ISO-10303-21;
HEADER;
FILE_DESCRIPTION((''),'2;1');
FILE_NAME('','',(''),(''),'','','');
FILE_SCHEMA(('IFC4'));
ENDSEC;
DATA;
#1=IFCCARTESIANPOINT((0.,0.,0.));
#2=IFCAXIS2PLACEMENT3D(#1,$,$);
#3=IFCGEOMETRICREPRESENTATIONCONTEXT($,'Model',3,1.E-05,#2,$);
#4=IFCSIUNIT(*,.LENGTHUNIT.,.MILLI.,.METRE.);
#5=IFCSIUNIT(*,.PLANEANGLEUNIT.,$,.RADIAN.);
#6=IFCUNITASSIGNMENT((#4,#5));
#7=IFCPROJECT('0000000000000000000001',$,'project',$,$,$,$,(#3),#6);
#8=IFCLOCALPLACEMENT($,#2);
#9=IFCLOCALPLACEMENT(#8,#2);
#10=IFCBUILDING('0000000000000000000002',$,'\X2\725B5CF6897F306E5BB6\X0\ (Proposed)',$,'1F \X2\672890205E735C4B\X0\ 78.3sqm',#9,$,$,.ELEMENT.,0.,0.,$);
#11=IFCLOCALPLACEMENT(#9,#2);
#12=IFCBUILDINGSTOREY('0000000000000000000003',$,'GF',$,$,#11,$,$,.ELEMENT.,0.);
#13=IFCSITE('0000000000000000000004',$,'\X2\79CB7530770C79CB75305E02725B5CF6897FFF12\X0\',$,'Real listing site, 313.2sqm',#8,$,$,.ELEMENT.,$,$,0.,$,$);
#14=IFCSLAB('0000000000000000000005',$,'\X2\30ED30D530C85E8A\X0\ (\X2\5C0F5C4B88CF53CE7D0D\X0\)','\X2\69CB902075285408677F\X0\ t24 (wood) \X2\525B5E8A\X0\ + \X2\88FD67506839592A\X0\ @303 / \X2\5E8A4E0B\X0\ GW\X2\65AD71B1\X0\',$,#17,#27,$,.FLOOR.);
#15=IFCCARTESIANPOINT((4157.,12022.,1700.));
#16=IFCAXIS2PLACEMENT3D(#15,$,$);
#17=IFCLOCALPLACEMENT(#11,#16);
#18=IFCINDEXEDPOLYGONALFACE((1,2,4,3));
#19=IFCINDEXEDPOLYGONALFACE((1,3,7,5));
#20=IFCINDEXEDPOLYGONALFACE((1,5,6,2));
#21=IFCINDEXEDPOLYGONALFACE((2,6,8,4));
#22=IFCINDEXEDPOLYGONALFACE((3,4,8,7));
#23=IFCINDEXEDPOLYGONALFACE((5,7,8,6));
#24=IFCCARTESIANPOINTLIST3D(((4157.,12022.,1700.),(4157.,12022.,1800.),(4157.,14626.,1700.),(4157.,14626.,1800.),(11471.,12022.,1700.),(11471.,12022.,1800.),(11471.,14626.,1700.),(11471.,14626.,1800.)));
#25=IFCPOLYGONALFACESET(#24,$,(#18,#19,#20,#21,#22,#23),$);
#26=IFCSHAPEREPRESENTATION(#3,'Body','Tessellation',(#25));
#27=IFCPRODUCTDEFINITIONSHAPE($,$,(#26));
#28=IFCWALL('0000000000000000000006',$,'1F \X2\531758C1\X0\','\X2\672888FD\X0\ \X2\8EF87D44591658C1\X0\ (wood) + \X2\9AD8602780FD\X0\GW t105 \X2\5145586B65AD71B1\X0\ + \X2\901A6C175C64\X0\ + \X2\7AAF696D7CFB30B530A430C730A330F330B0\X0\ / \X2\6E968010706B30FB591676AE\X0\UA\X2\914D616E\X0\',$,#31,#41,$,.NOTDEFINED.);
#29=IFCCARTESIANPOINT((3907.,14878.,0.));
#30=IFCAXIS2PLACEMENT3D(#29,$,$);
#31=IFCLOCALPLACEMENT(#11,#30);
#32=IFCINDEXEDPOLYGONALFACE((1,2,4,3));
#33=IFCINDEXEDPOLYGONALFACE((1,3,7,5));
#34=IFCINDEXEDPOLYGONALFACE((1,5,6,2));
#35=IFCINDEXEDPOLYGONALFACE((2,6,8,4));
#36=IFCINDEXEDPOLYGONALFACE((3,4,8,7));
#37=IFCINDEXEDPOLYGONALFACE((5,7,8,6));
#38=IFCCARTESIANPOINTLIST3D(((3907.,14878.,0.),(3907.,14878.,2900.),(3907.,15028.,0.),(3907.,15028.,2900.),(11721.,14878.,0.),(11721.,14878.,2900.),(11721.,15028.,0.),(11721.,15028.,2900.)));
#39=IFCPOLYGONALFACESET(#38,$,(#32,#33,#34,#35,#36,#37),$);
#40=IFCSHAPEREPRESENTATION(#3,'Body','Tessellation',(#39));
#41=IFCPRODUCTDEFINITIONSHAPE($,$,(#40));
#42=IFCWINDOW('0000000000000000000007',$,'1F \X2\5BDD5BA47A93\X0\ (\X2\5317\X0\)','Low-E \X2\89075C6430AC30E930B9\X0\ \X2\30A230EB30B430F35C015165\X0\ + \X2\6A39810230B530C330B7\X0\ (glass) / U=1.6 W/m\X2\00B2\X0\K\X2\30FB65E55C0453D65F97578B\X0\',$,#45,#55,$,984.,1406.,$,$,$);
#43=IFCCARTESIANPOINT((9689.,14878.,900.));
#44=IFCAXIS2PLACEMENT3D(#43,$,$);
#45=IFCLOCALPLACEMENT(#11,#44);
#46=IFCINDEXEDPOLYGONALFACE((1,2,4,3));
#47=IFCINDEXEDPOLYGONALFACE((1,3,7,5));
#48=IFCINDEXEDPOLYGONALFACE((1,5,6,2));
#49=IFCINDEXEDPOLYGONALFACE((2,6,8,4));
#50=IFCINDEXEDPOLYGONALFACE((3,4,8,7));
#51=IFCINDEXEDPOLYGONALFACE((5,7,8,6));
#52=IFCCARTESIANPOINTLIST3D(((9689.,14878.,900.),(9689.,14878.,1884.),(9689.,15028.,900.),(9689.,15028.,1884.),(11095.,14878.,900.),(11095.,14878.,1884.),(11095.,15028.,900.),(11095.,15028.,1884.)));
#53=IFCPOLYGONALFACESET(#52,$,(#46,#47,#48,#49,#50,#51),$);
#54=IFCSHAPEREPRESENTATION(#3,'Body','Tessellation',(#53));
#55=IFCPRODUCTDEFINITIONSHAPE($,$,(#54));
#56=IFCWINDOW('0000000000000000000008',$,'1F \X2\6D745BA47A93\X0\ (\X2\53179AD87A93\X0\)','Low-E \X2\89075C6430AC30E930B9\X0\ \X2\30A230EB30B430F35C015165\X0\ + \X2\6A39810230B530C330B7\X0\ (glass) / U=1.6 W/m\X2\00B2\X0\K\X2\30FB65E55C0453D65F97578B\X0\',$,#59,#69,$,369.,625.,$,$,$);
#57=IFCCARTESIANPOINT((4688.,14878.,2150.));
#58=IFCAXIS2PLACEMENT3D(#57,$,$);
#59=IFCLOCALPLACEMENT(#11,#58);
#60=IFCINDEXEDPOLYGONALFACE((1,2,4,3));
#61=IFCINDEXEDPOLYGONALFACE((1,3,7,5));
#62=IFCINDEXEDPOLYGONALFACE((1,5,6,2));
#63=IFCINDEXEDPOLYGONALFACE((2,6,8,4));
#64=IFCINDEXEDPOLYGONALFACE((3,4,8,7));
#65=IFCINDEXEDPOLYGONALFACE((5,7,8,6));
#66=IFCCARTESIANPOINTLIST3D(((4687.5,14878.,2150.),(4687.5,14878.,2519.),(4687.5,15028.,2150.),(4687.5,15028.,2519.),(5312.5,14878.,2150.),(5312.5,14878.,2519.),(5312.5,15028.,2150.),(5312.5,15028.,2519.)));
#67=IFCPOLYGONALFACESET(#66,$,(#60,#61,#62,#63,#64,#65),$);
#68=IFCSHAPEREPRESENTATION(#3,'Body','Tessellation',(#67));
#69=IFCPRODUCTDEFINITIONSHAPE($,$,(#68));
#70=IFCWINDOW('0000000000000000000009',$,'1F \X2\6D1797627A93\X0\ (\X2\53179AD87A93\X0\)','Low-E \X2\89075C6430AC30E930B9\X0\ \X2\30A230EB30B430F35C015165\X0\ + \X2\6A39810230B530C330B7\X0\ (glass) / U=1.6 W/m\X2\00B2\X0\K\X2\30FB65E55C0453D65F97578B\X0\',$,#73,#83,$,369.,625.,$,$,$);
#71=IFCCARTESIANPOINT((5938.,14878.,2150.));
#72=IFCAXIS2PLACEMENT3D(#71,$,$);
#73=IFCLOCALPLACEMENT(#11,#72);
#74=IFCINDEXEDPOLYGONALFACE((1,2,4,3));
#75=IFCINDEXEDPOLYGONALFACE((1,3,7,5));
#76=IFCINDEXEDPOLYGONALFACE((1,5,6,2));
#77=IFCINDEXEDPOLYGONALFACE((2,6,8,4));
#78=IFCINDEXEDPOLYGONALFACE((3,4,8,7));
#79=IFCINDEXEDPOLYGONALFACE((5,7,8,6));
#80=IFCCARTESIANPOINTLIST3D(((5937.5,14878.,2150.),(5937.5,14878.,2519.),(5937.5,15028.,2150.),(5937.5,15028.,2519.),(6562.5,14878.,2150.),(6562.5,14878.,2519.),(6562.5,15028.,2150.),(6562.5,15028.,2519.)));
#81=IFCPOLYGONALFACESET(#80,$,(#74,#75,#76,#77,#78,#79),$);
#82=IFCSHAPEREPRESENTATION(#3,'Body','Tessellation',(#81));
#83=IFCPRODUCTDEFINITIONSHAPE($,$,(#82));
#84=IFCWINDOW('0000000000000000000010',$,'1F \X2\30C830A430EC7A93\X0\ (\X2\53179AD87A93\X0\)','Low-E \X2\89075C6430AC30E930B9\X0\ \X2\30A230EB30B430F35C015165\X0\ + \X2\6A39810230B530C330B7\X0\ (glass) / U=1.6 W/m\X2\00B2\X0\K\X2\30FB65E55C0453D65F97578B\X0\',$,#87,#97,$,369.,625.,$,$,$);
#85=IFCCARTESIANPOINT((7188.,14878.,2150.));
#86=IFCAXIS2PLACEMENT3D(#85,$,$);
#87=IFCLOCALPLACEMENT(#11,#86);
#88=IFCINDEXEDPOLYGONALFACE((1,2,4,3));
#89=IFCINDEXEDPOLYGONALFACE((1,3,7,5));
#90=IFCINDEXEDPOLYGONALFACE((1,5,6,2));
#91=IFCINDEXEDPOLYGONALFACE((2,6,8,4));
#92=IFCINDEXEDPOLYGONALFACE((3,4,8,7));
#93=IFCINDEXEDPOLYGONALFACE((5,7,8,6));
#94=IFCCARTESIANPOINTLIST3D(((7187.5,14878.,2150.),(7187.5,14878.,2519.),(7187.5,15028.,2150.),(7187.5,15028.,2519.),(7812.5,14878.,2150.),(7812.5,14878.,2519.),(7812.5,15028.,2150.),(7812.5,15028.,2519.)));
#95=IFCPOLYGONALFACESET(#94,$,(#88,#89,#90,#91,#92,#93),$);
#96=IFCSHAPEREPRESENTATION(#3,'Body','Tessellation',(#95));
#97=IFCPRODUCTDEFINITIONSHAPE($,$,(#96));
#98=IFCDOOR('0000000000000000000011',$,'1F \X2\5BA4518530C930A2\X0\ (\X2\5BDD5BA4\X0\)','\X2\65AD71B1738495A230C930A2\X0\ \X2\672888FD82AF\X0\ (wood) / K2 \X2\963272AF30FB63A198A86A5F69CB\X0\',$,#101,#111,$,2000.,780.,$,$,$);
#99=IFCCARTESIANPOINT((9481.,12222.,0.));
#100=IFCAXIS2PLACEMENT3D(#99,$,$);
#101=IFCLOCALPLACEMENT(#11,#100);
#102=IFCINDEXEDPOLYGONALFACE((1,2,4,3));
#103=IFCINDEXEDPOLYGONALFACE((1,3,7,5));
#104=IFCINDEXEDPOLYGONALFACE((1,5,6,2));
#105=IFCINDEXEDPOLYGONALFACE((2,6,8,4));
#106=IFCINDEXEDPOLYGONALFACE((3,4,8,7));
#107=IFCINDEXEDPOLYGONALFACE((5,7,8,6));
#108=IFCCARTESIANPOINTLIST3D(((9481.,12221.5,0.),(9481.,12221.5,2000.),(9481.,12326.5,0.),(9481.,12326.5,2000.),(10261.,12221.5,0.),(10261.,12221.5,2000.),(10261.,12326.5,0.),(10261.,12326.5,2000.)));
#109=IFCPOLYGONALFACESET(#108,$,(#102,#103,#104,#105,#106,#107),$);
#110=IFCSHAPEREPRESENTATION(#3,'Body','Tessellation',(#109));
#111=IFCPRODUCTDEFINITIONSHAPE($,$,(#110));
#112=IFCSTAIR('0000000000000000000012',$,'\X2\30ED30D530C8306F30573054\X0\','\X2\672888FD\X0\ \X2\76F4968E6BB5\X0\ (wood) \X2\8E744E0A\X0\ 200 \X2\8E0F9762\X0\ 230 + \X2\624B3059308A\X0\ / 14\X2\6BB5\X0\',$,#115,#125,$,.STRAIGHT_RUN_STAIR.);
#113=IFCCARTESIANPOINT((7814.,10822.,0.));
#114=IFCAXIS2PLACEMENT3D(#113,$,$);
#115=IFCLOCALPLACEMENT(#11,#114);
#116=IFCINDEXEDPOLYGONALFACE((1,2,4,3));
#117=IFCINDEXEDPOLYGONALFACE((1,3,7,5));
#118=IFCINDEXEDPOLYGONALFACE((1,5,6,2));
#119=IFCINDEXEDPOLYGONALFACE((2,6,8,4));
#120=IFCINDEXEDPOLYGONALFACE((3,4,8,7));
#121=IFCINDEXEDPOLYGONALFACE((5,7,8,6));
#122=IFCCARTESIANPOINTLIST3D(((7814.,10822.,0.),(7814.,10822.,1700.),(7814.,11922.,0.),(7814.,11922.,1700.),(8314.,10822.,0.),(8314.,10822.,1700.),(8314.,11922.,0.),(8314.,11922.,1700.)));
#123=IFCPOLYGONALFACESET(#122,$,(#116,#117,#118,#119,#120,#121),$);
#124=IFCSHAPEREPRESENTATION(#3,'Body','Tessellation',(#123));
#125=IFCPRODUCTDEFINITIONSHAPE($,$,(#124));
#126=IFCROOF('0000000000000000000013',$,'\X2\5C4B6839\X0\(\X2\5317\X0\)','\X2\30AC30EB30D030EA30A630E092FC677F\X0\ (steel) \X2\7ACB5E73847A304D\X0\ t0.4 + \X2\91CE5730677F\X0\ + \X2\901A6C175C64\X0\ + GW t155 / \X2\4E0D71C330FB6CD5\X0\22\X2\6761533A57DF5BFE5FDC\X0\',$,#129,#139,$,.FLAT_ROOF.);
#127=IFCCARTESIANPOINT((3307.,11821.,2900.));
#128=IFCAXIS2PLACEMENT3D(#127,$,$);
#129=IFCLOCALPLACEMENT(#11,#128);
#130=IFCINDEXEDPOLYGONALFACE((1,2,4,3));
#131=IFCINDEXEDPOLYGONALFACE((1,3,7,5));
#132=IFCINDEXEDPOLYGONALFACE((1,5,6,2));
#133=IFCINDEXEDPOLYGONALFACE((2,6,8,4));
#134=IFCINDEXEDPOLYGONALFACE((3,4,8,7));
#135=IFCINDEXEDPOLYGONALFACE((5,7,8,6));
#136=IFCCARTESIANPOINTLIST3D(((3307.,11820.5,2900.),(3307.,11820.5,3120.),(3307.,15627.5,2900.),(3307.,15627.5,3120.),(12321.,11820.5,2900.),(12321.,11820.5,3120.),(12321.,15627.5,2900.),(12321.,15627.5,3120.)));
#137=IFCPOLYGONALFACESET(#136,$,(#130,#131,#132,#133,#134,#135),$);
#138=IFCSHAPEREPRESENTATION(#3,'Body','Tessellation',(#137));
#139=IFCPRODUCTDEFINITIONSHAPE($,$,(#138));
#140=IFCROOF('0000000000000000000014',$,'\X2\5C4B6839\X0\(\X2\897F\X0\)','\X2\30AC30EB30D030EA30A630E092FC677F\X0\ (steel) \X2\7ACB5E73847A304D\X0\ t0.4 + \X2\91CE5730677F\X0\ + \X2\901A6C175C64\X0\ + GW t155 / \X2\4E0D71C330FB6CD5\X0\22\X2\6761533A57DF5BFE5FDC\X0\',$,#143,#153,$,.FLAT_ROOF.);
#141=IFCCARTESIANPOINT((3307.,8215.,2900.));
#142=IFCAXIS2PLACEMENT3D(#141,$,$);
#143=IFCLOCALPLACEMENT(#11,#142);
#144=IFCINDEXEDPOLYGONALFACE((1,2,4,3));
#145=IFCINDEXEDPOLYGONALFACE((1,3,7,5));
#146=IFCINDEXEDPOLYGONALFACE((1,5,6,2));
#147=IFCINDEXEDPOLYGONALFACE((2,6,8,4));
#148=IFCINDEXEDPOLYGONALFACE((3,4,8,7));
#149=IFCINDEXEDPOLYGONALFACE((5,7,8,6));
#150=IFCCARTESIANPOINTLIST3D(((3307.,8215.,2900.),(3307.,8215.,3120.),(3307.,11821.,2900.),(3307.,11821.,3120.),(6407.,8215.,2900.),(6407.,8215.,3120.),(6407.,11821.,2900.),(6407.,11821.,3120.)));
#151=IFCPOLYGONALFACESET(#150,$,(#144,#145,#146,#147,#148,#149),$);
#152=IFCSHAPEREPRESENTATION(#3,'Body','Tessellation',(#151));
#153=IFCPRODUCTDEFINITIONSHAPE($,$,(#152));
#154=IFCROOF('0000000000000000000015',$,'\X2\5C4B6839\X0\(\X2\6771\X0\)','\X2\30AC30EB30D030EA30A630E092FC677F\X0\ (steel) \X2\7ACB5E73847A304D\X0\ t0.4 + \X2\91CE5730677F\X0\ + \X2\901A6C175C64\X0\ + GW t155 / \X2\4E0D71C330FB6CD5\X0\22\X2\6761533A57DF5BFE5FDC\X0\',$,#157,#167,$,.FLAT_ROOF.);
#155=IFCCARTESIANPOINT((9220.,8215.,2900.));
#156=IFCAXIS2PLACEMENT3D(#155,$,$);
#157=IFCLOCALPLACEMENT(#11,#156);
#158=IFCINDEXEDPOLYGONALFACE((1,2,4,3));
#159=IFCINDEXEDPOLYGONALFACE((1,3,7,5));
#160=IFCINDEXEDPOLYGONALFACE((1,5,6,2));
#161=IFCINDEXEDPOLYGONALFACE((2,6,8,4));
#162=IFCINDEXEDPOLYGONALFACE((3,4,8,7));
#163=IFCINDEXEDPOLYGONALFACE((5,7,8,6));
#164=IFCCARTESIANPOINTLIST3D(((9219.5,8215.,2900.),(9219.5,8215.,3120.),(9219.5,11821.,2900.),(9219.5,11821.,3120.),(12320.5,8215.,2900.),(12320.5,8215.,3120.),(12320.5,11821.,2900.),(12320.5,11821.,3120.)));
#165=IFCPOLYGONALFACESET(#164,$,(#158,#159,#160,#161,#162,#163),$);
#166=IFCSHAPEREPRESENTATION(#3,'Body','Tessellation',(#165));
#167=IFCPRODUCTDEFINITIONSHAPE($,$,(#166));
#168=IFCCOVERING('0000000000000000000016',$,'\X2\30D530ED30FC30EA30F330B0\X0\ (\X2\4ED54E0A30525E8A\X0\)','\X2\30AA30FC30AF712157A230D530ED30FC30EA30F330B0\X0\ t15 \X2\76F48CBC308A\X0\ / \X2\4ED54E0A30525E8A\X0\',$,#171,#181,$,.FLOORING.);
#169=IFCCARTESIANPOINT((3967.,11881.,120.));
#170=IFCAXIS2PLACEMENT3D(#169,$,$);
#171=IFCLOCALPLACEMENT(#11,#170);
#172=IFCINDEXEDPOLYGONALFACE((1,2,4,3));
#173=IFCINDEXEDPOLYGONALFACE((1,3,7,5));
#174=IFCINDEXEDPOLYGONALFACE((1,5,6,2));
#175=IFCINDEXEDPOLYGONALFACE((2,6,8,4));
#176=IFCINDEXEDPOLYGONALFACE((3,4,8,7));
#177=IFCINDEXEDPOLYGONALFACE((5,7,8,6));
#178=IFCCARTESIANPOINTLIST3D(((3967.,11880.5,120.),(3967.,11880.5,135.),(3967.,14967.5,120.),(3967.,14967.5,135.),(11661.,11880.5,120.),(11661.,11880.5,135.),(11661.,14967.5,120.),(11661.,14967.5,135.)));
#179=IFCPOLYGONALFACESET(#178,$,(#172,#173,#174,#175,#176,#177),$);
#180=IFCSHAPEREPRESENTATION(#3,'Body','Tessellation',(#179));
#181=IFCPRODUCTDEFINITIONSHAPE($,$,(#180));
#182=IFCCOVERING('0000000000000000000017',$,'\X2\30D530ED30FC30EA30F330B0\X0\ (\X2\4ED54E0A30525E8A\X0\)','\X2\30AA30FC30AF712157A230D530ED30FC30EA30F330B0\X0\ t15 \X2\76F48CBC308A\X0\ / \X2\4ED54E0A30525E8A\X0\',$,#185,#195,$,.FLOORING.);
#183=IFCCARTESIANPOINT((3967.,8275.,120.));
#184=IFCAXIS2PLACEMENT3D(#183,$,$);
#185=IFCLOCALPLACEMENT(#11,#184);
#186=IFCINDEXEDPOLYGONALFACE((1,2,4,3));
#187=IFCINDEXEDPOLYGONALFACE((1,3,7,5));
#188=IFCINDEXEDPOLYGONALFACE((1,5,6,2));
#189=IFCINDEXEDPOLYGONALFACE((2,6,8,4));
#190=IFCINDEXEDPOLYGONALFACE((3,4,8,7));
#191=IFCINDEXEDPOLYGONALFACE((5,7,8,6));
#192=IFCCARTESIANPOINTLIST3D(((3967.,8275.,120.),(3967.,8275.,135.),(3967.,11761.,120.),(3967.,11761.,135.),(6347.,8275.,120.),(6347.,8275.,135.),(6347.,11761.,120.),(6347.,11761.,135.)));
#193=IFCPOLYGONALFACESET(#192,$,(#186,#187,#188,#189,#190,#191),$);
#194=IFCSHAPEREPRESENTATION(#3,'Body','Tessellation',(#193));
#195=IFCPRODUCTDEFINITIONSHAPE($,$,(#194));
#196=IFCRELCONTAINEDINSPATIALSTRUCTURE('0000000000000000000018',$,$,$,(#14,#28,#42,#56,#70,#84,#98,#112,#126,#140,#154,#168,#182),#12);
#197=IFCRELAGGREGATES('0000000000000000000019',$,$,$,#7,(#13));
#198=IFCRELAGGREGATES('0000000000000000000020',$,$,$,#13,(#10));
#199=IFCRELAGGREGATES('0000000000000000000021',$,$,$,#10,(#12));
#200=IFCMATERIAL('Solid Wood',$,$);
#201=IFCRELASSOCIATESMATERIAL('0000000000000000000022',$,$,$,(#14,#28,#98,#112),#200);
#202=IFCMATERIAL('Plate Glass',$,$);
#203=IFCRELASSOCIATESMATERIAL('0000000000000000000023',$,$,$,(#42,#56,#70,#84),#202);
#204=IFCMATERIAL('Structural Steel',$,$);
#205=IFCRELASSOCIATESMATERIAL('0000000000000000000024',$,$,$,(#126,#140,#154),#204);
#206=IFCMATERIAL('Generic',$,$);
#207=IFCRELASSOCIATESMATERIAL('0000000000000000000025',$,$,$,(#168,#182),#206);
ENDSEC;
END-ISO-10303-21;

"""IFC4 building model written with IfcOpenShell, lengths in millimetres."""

from ifc_helpers import new_model, si_unit, frame, frame_2d, origin, place, context, project, spatial, rectangle, extrude, material, element, fill, save


model = new_model("IFC4")

# Units and contexts
model_context = context("Model", 3, precision=1e-05, world=origin())
ifc_project = project(units=[si_unit("LENGTHUNIT", "METRE", prefix="MILLI"), si_unit("PLANEANGLEUNIT", "RADIAN")], contexts=[model_context])

# Site, building, storey
site_placement = place(None, origin())
site = spatial("IfcSite", under=ifc_project, at=site_placement, Name="秋田県秋田市牛島西２", ObjectType="Real listing site, 313.2sqm", CompositionType="ELEMENT", RefElevation=0.0)
building_placement = place(site_placement, origin())
building = spatial("IfcBuilding", under=site, at=building_placement, Name="牛島西の家 (Proposed)", ObjectType="1F 木造平屋 78.3sqm", CompositionType="ELEMENT", ElevationOfRefHeight=0.0, ElevationOfTerrain=0.0)
storey_placement = place(building_placement, origin())
storey = spatial("IfcBuildingStorey", under=building, at=storey_placement, Name="GF", CompositionType="ELEMENT", Elevation=0.0)

# Slab
ifc_material_1 = material(Name="Solid Wood")
slab_1_placement = place(storey_placement, frame((4157.0, 12022.0, 1700.0)))
element("IfcSlab", 1, at=slab_1_placement, inside=storey, material=ifc_material_1, Name="ロフト床 (小屋裏収納)", Description="構造用合板 t24 (wood) 剛床 + 製材根太 @303 / 床下 GW断熱", PredefinedType="FLOOR", context=model_context, shape_type="SweptSolid", body=[
    extrude(rectangle(XDim=7314.0, YDim=2604.0, at=frame_2d((3657.0, 1302.0))), frame((4157.0, 12022.0, 1700.0)), (0.0, 0.0, 1.0), 100.0),
])

# Wall, openings, windows
wall_1_placement = place(storey_placement, frame((3907.0, 14878.0, 0.0)))
wall_1 = element("IfcWall", 2, at=wall_1_placement, inside=storey, material=ifc_material_1, Name="1F 北壁", Description="木製 軸組外壁 (wood) + 高性能GW t105 充填断熱 + 通気層 + 窯業系サイディング / 準耐火・外皮UA配慮", PredefinedType="NOTDEFINED", context=model_context, shape_type="SweptSolid", body=[
    extrude(rectangle(XDim=7814.0, YDim=150.0, at=frame_2d((3907.0, 75.0))), frame((3907.0, 14878.0, 0.0)), (0.0, 0.0, 1.0), 2900.0),
])
opening_1_placement = place(storey_placement, frame((9689.0, 14878.0, 900.0)))
opening_1 = element("IfcOpeningElement", 3, at=opening_1_placement, cuts=wall_1, PredefinedType="NOTDEFINED", context=model_context, shape_type="SweptSolid", body=[
    extrude(rectangle(XDim=1406.0, YDim=150.0, at=frame_2d((703.0, 75.0))), frame((9689.0, 14878.0, 900.0)), (0.0, 0.0, 1.0), 984.0),
])
opening_2_placement = place(storey_placement, frame((4688.0, 14878.0, 2150.0)))
opening_2 = element("IfcOpeningElement", 4, at=opening_2_placement, cuts=wall_1, PredefinedType="NOTDEFINED", context=model_context, shape_type="SweptSolid", body=[
    extrude(rectangle(XDim=625.0, YDim=150.0, at=frame_2d((312.0, 75.0))), frame((4688.0, 14878.0, 2150.0)), (0.0, 0.0, 1.0), 369.0),
])
opening_3_placement = place(storey_placement, frame((5938.0, 14878.0, 2150.0)))
opening_3 = element("IfcOpeningElement", 5, at=opening_3_placement, cuts=wall_1, PredefinedType="NOTDEFINED", context=model_context, shape_type="SweptSolid", body=[
    extrude(rectangle(XDim=625.0, YDim=150.0, at=frame_2d((312.0, 75.0))), frame((5938.0, 14878.0, 2150.0)), (0.0, 0.0, 1.0), 369.0),
])
opening_4_placement = place(storey_placement, frame((7188.0, 14878.0, 2150.0)))
opening_4 = element("IfcOpeningElement", 6, at=opening_4_placement, cuts=wall_1, PredefinedType="NOTDEFINED", context=model_context, shape_type="SweptSolid", body=[
    extrude(rectangle(XDim=625.0, YDim=150.0, at=frame_2d((312.0, 75.0))), frame((7188.0, 14878.0, 2150.0)), (0.0, 0.0, 1.0), 369.0),
])
ifc_material_2 = material(Name="Plate Glass")
window_1_placement = place(storey_placement, frame((9689.0, 14878.0, 900.0)))
window_1 = element("IfcWindow", 7, at=window_1_placement, inside=storey, material=ifc_material_2, Name="1F 寝室窓 (北)", Description="Low-E 複層ガラス アルゴン封入 + 樹脂サッシ (glass) / U=1.6 W/m²K・日射取得型", OverallHeight=984.0, OverallWidth=1406.0, context=model_context, shape_type="SweptSolid", body=[
    extrude(rectangle(XDim=1406.0, YDim=150.0, at=frame_2d((703.0, 75.0))), frame((9689.0, 14878.0, 900.0)), (0.0, 0.0, 1.0), 984.0),
])
fill(opening_1, window_1)
window_2_placement = place(storey_placement, frame((4688.0, 14878.0, 2150.0)))
window_2 = element("IfcWindow", 8, at=window_2_placement, inside=storey, material=ifc_material_2, Name="1F 浴室窓 (北高窓)", Description="Low-E 複層ガラス アルゴン封入 + 樹脂サッシ (glass) / U=1.6 W/m²K・日射取得型", OverallHeight=369.0, OverallWidth=625.0, context=model_context, shape_type="SweptSolid", body=[
    extrude(rectangle(XDim=625.0, YDim=150.0, at=frame_2d((312.0, 75.0))), frame((4688.0, 14878.0, 2150.0)), (0.0, 0.0, 1.0), 369.0),
])
fill(opening_2, window_2)
window_3_placement = place(storey_placement, frame((5938.0, 14878.0, 2150.0)))
window_3 = element("IfcWindow", 9, at=window_3_placement, inside=storey, material=ifc_material_2, Name="1F 洗面窓 (北高窓)", Description="Low-E 複層ガラス アルゴン封入 + 樹脂サッシ (glass) / U=1.6 W/m²K・日射取得型", OverallHeight=369.0, OverallWidth=625.0, context=model_context, shape_type="SweptSolid", body=[
    extrude(rectangle(XDim=625.0, YDim=150.0, at=frame_2d((312.0, 75.0))), frame((5938.0, 14878.0, 2150.0)), (0.0, 0.0, 1.0), 369.0),
])
fill(opening_3, window_3)
window_4_placement = place(storey_placement, frame((7188.0, 14878.0, 2150.0)))
window_4 = element("IfcWindow", 10, at=window_4_placement, inside=storey, material=ifc_material_2, Name="1F トイレ窓 (北高窓)", Description="Low-E 複層ガラス アルゴン封入 + 樹脂サッシ (glass) / U=1.6 W/m²K・日射取得型", OverallHeight=369.0, OverallWidth=625.0, context=model_context, shape_type="SweptSolid", body=[
    extrude(rectangle(XDim=625.0, YDim=150.0, at=frame_2d((312.0, 75.0))), frame((7188.0, 14878.0, 2150.0)), (0.0, 0.0, 1.0), 369.0),
])
fill(opening_4, window_4)

# Door
door_1_placement = place(storey_placement, frame((9481.0, 12222.0, 0.0)))
element("IfcDoor", 11, at=door_1_placement, inside=storey, material=ifc_material_1, Name="1F 室内ドア (寝室)", Description="断熱玄関ドア 木製芯 (wood) / K2 防犯・採風機構", OverallHeight=2000.0, OverallWidth=780.0, context=model_context, shape_type="SweptSolid", body=[
    extrude(rectangle(XDim=780.0, YDim=105.0, at=frame_2d((390.0, 52.0))), frame((9481.0, 12222.0, 0.0)), (0.0, 0.0, 1.0), 2000.0),
])

# Stair
stair_placement = place(storey_placement, frame((7814.0, 10822.0, 0.0)))
element("IfcStair", 12, at=stair_placement, inside=storey, material=ifc_material_1, Name="ロフトはしご", Description="木製 直階段 (wood) 蹴上 200 踏面 230 + 手すり / 14段", PredefinedType="STRAIGHT_RUN_STAIR", context=model_context, shape_type="SweptSolid", body=[
    extrude(rectangle(XDim=500.0, YDim=1100.0, at=frame_2d((250.0, 550.0))), frame((7814.0, 10822.0, 0.0)), (0.0, 0.0, 1.0), 1700.0),
])

# Roofs
ifc_material_3 = material(Name="Structural Steel")
roof_1_placement = place(storey_placement, frame((3307.0, 11821.0, 2900.0)))
element("IfcRoof", 13, at=roof_1_placement, inside=storey, material=ifc_material_3, Name="屋根(北)", Description="ガルバリウム鋼板 (steel) 立平葺き t0.4 + 野地板 + 通気層 + GW t155 / 不燃・法22条区域対応", PredefinedType="FLAT_ROOF", context=model_context, shape_type="SweptSolid", body=[
    extrude(rectangle(XDim=9014.0, YDim=3807.0, at=frame_2d((4507.0, 1903.0))), frame((3307.0, 11821.0, 2900.0)), (0.0, 0.0, 1.0), 220.0),
])
roof_2_placement = place(storey_placement, frame((3307.0, 8215.0, 2900.0)))
element("IfcRoof", 14, at=roof_2_placement, inside=storey, material=ifc_material_3, Name="屋根(西)", Description="ガルバリウム鋼板 (steel) 立平葺き t0.4 + 野地板 + 通気層 + GW t155 / 不燃・法22条区域対応", PredefinedType="FLAT_ROOF", context=model_context, shape_type="SweptSolid", body=[
    extrude(rectangle(XDim=3100.0, YDim=3606.0, at=frame_2d((1550.0, 1803.0))), frame((3307.0, 8215.0, 2900.0)), (0.0, 0.0, 1.0), 220.0),
])
roof_3_placement = place(storey_placement, frame((9220.0, 8215.0, 2900.0)))
element("IfcRoof", 15, at=roof_3_placement, inside=storey, material=ifc_material_3, Name="屋根(東)", Description="ガルバリウム鋼板 (steel) 立平葺き t0.4 + 野地板 + 通気層 + GW t155 / 不燃・法22条区域対応", PredefinedType="FLAT_ROOF", context=model_context, shape_type="SweptSolid", body=[
    extrude(rectangle(XDim=3101.0, YDim=3606.0, at=frame_2d((1550.0, 1803.0))), frame((9220.0, 8215.0, 2900.0)), (0.0, 0.0, 1.0), 220.0),
])

# Coverings
ifc_material_4 = material(Name="Generic")
covering_1_placement = place(storey_placement, frame((3967.0, 11881.0, 120.0)))
element("IfcCovering", 16, at=covering_1_placement, inside=storey, material=ifc_material_4, Name="フローリング (仕上げ床)", Description="オーク無垢フローリング t15 直貼り / 仕上げ床", PredefinedType="FLOORING", context=model_context, shape_type="SweptSolid", body=[
    extrude(rectangle(XDim=7694.0, YDim=3087.0, at=frame_2d((3847.0, 1543.0))), frame((3967.0, 11881.0, 120.0)), (0.0, 0.0, 1.0), 15.0),
])
covering_2_placement = place(storey_placement, frame((3967.0, 8275.0, 120.0)))
element("IfcCovering", 17, at=covering_2_placement, inside=storey, material=ifc_material_4, Name="フローリング (仕上げ床)", Description="オーク無垢フローリング t15 直貼り / 仕上げ床", PredefinedType="FLOORING", context=model_context, shape_type="SweptSolid", body=[
    extrude(rectangle(XDim=2380.0, YDim=3486.0, at=frame_2d((1190.0, 1743.0))), frame((3967.0, 8275.0, 120.0)), (0.0, 0.0, 1.0), 15.0),
])

save(model, "model.ifc")
